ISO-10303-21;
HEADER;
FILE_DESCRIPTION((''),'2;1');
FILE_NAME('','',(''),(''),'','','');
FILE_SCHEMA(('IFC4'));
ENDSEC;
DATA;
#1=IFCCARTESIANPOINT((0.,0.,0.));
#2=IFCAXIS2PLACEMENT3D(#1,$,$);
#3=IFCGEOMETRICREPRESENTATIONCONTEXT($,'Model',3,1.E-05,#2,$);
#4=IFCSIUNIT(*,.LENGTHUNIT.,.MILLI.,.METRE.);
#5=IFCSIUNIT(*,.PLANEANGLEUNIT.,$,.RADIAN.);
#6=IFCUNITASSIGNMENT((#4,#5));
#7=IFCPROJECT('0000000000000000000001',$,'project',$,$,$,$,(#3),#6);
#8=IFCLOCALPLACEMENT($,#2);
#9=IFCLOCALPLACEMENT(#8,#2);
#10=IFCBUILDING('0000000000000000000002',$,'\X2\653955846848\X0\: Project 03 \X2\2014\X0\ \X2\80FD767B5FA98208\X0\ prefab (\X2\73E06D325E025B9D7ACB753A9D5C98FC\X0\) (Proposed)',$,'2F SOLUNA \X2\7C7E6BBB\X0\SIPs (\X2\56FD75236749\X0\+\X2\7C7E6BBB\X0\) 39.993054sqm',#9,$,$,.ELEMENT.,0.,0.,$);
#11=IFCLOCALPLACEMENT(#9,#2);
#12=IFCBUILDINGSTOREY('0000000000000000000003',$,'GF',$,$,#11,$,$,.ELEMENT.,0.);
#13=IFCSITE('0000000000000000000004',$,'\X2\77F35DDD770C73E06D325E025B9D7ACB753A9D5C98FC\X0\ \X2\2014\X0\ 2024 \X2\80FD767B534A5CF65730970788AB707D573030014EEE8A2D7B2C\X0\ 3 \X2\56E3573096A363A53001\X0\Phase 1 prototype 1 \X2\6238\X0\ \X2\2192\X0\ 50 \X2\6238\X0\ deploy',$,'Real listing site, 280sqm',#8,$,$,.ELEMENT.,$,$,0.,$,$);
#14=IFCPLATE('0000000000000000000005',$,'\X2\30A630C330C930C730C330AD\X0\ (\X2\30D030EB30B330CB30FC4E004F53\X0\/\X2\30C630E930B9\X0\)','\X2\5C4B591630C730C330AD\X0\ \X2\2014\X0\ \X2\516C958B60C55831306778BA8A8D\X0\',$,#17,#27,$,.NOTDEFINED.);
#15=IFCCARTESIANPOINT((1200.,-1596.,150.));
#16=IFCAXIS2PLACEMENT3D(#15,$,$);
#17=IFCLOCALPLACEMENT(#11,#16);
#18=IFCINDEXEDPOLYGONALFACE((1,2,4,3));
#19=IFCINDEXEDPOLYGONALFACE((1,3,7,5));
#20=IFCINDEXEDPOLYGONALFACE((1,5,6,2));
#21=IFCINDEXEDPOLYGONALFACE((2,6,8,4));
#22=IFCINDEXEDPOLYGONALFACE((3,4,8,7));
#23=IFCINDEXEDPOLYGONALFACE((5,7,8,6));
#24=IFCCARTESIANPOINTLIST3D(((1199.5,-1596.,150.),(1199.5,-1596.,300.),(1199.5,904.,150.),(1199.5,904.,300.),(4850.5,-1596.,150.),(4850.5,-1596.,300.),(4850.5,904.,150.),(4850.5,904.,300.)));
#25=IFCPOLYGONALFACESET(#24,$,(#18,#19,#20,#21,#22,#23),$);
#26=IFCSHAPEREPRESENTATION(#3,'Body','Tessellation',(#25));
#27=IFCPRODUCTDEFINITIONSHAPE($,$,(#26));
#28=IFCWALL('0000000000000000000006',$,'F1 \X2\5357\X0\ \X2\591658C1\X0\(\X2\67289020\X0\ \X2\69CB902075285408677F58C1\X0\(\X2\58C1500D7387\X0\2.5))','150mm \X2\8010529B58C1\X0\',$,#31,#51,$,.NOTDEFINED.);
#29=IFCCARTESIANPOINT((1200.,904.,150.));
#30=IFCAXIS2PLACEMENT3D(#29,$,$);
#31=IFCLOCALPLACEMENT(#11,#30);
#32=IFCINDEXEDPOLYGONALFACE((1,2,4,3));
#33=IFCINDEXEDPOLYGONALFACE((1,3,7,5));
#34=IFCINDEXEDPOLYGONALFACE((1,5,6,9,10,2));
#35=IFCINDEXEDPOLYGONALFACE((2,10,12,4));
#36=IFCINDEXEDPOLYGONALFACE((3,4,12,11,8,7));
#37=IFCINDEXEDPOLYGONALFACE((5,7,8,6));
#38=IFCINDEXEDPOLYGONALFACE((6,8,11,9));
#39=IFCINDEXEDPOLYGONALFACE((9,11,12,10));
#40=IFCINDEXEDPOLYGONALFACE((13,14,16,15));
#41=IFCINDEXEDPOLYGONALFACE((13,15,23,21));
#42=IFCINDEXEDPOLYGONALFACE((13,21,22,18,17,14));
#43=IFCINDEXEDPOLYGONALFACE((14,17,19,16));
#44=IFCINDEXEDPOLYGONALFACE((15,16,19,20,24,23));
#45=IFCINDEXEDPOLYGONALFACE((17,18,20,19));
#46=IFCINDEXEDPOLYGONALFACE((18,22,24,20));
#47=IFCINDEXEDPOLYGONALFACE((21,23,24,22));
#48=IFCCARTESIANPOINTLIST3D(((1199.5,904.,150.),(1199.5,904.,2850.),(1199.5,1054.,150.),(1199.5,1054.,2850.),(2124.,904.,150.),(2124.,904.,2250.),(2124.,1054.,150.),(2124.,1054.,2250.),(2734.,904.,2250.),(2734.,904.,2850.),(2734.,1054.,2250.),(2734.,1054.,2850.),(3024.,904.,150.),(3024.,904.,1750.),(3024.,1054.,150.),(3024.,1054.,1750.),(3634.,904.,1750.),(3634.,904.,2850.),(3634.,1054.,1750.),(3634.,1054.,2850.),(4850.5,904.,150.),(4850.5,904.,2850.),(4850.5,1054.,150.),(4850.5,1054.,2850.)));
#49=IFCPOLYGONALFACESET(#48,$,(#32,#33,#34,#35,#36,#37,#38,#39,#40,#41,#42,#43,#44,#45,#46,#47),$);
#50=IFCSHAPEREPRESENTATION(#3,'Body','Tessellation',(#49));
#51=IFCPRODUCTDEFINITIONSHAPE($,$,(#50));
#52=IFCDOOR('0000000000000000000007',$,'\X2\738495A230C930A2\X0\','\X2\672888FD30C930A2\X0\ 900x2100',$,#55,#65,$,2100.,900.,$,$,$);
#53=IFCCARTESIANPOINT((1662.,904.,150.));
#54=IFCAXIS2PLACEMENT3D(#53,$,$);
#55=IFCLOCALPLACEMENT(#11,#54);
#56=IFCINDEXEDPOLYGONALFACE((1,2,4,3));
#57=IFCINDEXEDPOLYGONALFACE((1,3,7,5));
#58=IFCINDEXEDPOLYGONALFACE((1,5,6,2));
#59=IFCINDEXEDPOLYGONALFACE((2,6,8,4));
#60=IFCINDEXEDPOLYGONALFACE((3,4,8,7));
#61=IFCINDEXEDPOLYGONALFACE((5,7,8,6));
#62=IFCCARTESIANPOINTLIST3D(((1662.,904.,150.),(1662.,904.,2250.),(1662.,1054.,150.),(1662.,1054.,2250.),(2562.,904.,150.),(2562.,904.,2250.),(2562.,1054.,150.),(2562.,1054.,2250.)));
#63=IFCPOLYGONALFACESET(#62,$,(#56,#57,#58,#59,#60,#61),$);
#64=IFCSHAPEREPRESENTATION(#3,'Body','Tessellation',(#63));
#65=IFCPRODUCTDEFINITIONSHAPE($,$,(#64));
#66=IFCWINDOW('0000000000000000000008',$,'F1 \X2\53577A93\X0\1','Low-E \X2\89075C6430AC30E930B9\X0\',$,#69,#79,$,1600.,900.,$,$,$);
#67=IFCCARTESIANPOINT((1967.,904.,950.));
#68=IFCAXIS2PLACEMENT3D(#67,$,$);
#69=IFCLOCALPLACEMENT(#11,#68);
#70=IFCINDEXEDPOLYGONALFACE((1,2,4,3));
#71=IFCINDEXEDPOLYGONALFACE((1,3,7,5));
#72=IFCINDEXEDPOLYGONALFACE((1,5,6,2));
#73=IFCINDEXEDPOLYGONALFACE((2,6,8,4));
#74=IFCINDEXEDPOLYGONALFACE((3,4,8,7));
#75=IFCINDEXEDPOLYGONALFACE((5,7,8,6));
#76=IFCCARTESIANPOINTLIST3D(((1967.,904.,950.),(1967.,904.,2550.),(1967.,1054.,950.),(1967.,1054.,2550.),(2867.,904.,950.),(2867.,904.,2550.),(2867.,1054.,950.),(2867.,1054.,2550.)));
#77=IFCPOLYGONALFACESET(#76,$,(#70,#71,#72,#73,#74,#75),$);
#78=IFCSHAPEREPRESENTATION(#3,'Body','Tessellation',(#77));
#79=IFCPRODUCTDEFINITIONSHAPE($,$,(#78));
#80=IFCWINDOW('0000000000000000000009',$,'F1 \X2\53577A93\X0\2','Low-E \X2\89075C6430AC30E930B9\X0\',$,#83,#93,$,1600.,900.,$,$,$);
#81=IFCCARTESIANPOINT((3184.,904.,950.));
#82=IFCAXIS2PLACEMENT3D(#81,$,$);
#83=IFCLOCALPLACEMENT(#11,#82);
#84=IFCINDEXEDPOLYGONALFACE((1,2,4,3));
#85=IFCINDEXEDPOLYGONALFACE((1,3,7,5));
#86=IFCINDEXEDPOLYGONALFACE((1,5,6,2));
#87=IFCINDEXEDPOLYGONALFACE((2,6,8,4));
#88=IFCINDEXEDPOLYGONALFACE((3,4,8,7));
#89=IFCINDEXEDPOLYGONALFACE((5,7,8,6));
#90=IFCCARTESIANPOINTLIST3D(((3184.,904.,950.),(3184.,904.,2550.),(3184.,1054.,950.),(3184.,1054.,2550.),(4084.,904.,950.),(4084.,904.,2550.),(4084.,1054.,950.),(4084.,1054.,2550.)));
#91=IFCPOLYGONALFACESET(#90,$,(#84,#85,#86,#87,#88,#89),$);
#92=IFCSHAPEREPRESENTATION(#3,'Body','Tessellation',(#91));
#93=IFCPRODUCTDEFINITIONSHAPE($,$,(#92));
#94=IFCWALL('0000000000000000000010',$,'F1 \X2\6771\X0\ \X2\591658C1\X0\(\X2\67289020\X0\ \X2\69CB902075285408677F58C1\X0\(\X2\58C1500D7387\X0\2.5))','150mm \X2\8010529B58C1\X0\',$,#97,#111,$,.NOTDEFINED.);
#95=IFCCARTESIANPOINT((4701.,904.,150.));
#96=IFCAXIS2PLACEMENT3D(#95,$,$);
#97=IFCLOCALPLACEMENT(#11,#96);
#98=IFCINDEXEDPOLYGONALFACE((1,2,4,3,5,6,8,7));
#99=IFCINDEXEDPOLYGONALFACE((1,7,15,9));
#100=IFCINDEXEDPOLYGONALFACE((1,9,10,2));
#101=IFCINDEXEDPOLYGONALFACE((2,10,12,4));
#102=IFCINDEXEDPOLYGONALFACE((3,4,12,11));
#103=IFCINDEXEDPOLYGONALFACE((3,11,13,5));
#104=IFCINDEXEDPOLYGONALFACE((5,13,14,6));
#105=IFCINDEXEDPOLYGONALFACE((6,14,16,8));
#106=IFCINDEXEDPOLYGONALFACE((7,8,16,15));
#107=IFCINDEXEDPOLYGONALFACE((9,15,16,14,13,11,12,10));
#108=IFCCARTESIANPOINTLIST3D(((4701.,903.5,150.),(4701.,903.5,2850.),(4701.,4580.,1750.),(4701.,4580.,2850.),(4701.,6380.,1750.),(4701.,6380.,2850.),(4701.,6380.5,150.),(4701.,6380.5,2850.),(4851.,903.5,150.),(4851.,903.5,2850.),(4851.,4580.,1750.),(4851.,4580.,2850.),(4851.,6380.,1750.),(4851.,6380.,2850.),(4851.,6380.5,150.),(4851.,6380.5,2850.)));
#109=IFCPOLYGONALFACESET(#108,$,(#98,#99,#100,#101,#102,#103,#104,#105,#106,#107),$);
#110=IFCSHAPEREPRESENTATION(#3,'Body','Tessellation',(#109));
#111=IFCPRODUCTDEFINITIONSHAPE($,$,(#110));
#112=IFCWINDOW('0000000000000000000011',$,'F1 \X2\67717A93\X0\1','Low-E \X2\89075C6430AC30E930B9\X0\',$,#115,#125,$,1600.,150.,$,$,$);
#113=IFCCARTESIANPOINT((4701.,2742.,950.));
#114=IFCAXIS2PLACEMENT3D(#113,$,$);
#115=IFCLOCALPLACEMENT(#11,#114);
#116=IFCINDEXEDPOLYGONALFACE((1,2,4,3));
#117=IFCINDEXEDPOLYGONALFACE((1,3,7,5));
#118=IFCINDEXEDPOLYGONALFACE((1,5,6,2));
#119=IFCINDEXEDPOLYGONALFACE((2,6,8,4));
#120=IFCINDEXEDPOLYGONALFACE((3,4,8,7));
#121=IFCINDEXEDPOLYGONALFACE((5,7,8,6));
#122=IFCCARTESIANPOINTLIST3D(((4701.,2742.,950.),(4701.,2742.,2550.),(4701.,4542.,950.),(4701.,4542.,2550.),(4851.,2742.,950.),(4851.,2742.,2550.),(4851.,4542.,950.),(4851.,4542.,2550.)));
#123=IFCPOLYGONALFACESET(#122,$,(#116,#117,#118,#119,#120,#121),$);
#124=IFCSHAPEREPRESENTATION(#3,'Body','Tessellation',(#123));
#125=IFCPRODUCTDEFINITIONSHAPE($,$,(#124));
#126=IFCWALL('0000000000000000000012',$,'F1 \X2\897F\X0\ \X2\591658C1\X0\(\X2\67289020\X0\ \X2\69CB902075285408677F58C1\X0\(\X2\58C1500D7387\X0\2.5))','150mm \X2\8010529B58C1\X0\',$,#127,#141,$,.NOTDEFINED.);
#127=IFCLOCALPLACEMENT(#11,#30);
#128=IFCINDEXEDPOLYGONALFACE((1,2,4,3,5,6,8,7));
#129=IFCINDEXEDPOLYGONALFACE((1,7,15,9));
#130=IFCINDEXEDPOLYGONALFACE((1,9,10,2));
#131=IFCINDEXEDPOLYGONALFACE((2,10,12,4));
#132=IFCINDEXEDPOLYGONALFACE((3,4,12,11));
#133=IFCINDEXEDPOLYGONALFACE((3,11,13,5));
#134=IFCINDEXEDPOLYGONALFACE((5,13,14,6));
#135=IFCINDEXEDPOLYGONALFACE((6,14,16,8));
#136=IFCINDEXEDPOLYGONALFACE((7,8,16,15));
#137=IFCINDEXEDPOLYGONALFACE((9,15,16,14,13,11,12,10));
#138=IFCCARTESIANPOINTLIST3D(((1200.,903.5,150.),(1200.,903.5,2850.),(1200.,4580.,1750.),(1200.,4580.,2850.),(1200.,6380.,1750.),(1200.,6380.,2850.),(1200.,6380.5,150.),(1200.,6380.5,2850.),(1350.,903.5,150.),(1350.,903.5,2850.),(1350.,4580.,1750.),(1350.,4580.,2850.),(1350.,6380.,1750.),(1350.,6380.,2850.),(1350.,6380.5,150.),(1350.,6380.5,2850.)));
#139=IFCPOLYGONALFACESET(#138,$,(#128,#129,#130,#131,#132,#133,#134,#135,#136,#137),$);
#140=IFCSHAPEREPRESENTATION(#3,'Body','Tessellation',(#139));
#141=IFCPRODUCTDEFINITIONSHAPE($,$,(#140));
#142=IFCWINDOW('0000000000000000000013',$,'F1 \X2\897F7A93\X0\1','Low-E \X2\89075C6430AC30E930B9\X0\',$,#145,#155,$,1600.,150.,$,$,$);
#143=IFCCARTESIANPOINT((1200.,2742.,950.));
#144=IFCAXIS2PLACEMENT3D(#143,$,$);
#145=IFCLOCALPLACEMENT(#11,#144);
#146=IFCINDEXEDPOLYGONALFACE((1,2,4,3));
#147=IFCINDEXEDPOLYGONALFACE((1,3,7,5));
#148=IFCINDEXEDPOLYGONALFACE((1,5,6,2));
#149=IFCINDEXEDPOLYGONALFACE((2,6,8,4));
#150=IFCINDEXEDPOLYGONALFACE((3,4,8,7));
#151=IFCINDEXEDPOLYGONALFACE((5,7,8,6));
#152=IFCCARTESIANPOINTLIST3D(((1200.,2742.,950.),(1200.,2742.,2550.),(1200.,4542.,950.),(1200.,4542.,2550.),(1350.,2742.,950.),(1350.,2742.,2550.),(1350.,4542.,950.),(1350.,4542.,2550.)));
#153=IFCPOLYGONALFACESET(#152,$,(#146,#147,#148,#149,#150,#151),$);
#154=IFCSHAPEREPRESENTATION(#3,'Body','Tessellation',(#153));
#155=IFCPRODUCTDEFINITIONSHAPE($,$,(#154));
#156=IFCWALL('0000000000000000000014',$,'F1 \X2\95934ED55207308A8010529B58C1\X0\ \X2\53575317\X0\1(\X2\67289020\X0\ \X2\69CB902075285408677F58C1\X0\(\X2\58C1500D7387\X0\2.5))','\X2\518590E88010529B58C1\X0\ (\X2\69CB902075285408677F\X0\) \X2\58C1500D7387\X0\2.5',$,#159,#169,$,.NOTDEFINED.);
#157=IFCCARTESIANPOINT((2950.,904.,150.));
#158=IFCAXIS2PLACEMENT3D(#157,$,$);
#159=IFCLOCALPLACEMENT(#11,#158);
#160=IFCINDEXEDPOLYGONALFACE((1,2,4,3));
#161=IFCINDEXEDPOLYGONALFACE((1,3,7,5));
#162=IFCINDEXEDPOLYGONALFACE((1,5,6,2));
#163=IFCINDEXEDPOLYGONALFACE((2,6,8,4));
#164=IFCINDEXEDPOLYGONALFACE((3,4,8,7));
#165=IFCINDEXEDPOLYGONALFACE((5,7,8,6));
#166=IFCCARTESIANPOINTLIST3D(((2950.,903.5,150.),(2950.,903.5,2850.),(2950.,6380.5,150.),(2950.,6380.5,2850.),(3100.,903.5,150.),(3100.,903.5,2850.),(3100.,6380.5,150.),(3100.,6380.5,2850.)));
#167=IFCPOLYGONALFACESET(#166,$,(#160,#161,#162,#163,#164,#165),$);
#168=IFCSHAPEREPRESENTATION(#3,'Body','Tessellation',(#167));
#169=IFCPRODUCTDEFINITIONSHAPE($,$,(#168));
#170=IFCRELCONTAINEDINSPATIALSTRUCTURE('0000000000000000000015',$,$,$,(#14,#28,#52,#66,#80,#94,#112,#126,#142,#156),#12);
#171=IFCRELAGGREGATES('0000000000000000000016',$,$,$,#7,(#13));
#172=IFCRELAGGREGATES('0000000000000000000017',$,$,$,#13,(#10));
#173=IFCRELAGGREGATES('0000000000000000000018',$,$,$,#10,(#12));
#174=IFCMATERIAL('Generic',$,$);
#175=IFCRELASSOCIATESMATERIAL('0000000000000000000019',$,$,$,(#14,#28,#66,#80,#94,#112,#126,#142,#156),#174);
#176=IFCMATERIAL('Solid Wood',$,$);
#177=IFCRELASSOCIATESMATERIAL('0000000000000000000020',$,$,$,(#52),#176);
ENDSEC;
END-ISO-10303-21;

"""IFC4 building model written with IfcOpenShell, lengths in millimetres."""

from ifc_helpers import new_model, si_unit, frame, frame_2d, origin, place, context, project, spatial, rectangle, extrude, material, element, fill, save


model = new_model("IFC4")

# Units and contexts
model_context = context("Model", 3, precision=1e-05, world=origin())
ifc_project = project(units=[si_unit("LENGTHUNIT", "METRE", prefix="MILLI"), si_unit("PLANEANGLEUNIT", "RADIAN")], contexts=[model_context])

# Site, building, storey
site_placement = place(None, origin())
site = spatial("IfcSite", under=ifc_project, at=site_placement, Name="石川県珠洲市宝立町鵜飼 — 2024 能登半島地震被災地、仮設第 3 団地隣接、Phase 1 prototype 1 戸 → 50 戸 deploy", ObjectType="Real listing site, 280sqm", CompositionType="ELEMENT", RefElevation=0.0)
building_placement = place(site_placement, origin())
building = spatial("IfcBuilding", under=site, at=building_placement, Name="改善案: Project 03 — 能登復興 prefab (珠洲市宝立町鵜飼) (Proposed)", ObjectType="2F SOLUNA 籾殻SIPs (国産杉+籾殻) 39.993054sqm", CompositionType="ELEMENT", ElevationOfRefHeight=0.0, ElevationOfTerrain=0.0)
storey_placement = place(building_placement, origin())
storey = spatial("IfcBuildingStorey", under=building, at=storey_placement, Name="GF", CompositionType="ELEMENT", Elevation=0.0)

# Shared definitions
ifc_material_1 = material(Name="Generic")

# Plate
plate_placement = place(storey_placement, frame((1200.0, -1596.0, 150.0)))
element("IfcPlate", 1, at=plate_placement, inside=storey, material=ifc_material_1, Name="ウッドデッキ (バルコニー一体/テラス)", Description="屋外デッキ — 公開情報で確認", PredefinedType="NOTDEFINED", context=model_context, shape_type="SweptSolid", body=[
    extrude(rectangle(XDim=3651.0, YDim=2500.0, at=frame_2d((1825.0, 1250.0))), frame((1200.0, -1596.0, 150.0)), (0.0, 0.0, 1.0), 150.0),
])

# Wall, openings, door, windows
wall_1_placement = place(storey_placement, frame((1200.0, 904.0, 150.0)))
wall_1 = element("IfcWall", 2, at=wall_1_placement, inside=storey, material=ifc_material_1, Name="F1 南 外壁(木造 構造用合板壁(壁倍率2.5))", Description="150mm 耐力壁", PredefinedType="NOTDEFINED", context=model_context, shape_type="SweptSolid", body=[
    extrude(rectangle(XDim=3651.0, YDim=150.0, at=frame_2d((1825.0, 75.0))), frame((1200.0, 904.0, 150.0)), (0.0, 0.0, 1.0), 2700.0),
])
opening_1_placement = place(storey_placement, frame((1662.0, 904.0, 150.0)))
opening_1 = element("IfcOpeningElement", 3, at=opening_1_placement, cuts=wall_1, PredefinedType="NOTDEFINED", context=model_context, shape_type="SweptSolid", body=[
    extrude(rectangle(XDim=900.0, YDim=150.0, at=frame_2d((450.0, 75.0))), frame((1662.0, 904.0, 150.0)), (0.0, 0.0, 1.0), 2100.0),
])
opening_2_placement = place(storey_placement, frame((1967.0, 904.0, 950.0)))
opening_2 = element("IfcOpeningElement", 4, at=opening_2_placement, cuts=wall_1, PredefinedType="NOTDEFINED", context=model_context, shape_type="SweptSolid", body=[
    extrude(rectangle(XDim=900.0, YDim=150.0, at=frame_2d((450.0, 75.0))), frame((1967.0, 904.0, 950.0)), (0.0, 0.0, 1.0), 1600.0),
])
opening_3_placement = place(storey_placement, frame((3184.0, 904.0, 950.0)))
opening_3 = element("IfcOpeningElement", 5, at=opening_3_placement, cuts=wall_1, PredefinedType="NOTDEFINED", context=model_context, shape_type="SweptSolid", body=[
    extrude(rectangle(XDim=900.0, YDim=150.0, at=frame_2d((450.0, 75.0))), frame((3184.0, 904.0, 950.0)), (0.0, 0.0, 1.0), 1600.0),
])
ifc_material_2 = material(Name="Solid Wood")
door_placement = place(storey_placement, frame((1662.0, 904.0, 150.0)))
door = element("IfcDoor", 6, at=door_placement, inside=storey, material=ifc_material_2, Name="玄関ドア", Description="木製ドア 900x2100", OverallHeight=2100.0, OverallWidth=900.0, context=model_context, shape_type="SweptSolid", body=[
    extrude(rectangle(XDim=900.0, YDim=150.0, at=frame_2d((450.0, 75.0))), frame((1662.0, 904.0, 150.0)), (0.0, 0.0, 1.0), 2100.0),
])
fill(opening_1, door)
window_1_placement = place(storey_placement, frame((1967.0, 904.0, 950.0)))
window_1 = element("IfcWindow", 7, at=window_1_placement, inside=storey, material=ifc_material_1, Name="F1 南窓1", Description="Low-E 複層ガラス", OverallHeight=1600.0, OverallWidth=900.0, context=model_context, shape_type="SweptSolid", body=[
    extrude(rectangle(XDim=900.0, YDim=150.0, at=frame_2d((450.0, 75.0))), frame((1967.0, 904.0, 950.0)), (0.0, 0.0, 1.0), 1600.0),
])
fill(opening_2, window_1)
window_2_placement = place(storey_placement, frame((3184.0, 904.0, 950.0)))
window_2 = element("IfcWindow", 8, at=window_2_placement, inside=storey, material=ifc_material_1, Name="F1 南窓2", Description="Low-E 複層ガラス", OverallHeight=1600.0, OverallWidth=900.0, context=model_context, shape_type="SweptSolid", body=[
    extrude(rectangle(XDim=900.0, YDim=150.0, at=frame_2d((450.0, 75.0))), frame((3184.0, 904.0, 950.0)), (0.0, 0.0, 1.0), 1600.0),
])
fill(opening_3, window_2)

# Walls, openings, windows
wall_2_placement = place(storey_placement, frame((4701.0, 904.0, 150.0)))
wall_2 = element("IfcWall", 9, at=wall_2_placement, inside=storey, material=ifc_material_1, Name="F1 東 外壁(木造 構造用合板壁(壁倍率2.5))", Description="150mm 耐力壁", PredefinedType="NOTDEFINED", context=model_context, shape_type="SweptSolid", body=[
    extrude(rectangle(XDim=150.0, YDim=5477.0, at=frame_2d((75.0, 2738.0))), frame((4701.0, 904.0, 150.0)), (0.0, 0.0, 1.0), 2700.0),
])
opening_4_placement = place(storey_placement, frame((4701.0, 2742.0, 950.0)))
opening_4 = element("IfcOpeningElement", 10, at=opening_4_placement, cuts=wall_2, PredefinedType="NOTDEFINED", context=model_context, shape_type="SweptSolid", body=[
    extrude(rectangle(XDim=150.0, YDim=1800.0, at=frame_2d((75.0, 900.0))), frame((4701.0, 2742.0, 950.0)), (0.0, 0.0, 1.0), 1600.0),
])
window_3_placement = place(storey_placement, frame((4701.0, 2742.0, 950.0)))
window_3 = element("IfcWindow", 11, at=window_3_placement, inside=storey, material=ifc_material_1, Name="F1 東窓1", Description="Low-E 複層ガラス", OverallHeight=1600.0, OverallWidth=150.0, context=model_context, shape_type="SweptSolid", body=[
    extrude(rectangle(XDim=150.0, YDim=1800.0, at=frame_2d((75.0, 900.0))), frame((4701.0, 2742.0, 950.0)), (0.0, 0.0, 1.0), 1600.0),
])
fill(opening_4, window_3)
wall_3_placement = place(storey_placement, frame((1200.0, 904.0, 150.0)))
wall_3 = element("IfcWall", 12, at=wall_3_placement, inside=storey, material=ifc_material_1, Name="F1 西 外壁(木造 構造用合板壁(壁倍率2.5))", Description="150mm 耐力壁", PredefinedType="NOTDEFINED", context=model_context, shape_type="SweptSolid", body=[
    extrude(rectangle(XDim=150.0, YDim=5477.0, at=frame_2d((75.0, 2738.0))), frame((1200.0, 904.0, 150.0)), (0.0, 0.0, 1.0), 2700.0),
])
opening_5_placement = place(storey_placement, frame((1200.0, 2742.0, 950.0)))
opening_5 = element("IfcOpeningElement", 13, at=opening_5_placement, cuts=wall_3, PredefinedType="NOTDEFINED", context=model_context, shape_type="SweptSolid", body=[
    extrude(rectangle(XDim=150.0, YDim=1800.0, at=frame_2d((75.0, 900.0))), frame((1200.0, 2742.0, 950.0)), (0.0, 0.0, 1.0), 1600.0),
])
window_4_placement = place(storey_placement, frame((1200.0, 2742.0, 950.0)))
window_4 = element("IfcWindow", 14, at=window_4_placement, inside=storey, material=ifc_material_1, Name="F1 西窓1", Description="Low-E 複層ガラス", OverallHeight=1600.0, OverallWidth=150.0, context=model_context, shape_type="SweptSolid", body=[
    extrude(rectangle(XDim=150.0, YDim=1800.0, at=frame_2d((75.0, 900.0))), frame((1200.0, 2742.0, 950.0)), (0.0, 0.0, 1.0), 1600.0),
])
fill(opening_5, window_4)

# Wall
wall_4_placement = place(storey_placement, frame((2950.0, 904.0, 150.0)))
element("IfcWall", 15, at=wall_4_placement, inside=storey, material=ifc_material_1, Name="F1 間仕切り耐力壁 南北1(木造 構造用合板壁(壁倍率2.5))", Description="内部耐力壁 (構造用合板) 壁倍率2.5", PredefinedType="NOTDEFINED", context=model_context, shape_type="SweptSolid", body=[
    extrude(rectangle(XDim=150.0, YDim=5477.0, at=frame_2d((75.0, 2738.0))), frame((2950.0, 904.0, 150.0)), (0.0, 0.0, 1.0), 2700.0),
])

save(model, "model.ifc")
